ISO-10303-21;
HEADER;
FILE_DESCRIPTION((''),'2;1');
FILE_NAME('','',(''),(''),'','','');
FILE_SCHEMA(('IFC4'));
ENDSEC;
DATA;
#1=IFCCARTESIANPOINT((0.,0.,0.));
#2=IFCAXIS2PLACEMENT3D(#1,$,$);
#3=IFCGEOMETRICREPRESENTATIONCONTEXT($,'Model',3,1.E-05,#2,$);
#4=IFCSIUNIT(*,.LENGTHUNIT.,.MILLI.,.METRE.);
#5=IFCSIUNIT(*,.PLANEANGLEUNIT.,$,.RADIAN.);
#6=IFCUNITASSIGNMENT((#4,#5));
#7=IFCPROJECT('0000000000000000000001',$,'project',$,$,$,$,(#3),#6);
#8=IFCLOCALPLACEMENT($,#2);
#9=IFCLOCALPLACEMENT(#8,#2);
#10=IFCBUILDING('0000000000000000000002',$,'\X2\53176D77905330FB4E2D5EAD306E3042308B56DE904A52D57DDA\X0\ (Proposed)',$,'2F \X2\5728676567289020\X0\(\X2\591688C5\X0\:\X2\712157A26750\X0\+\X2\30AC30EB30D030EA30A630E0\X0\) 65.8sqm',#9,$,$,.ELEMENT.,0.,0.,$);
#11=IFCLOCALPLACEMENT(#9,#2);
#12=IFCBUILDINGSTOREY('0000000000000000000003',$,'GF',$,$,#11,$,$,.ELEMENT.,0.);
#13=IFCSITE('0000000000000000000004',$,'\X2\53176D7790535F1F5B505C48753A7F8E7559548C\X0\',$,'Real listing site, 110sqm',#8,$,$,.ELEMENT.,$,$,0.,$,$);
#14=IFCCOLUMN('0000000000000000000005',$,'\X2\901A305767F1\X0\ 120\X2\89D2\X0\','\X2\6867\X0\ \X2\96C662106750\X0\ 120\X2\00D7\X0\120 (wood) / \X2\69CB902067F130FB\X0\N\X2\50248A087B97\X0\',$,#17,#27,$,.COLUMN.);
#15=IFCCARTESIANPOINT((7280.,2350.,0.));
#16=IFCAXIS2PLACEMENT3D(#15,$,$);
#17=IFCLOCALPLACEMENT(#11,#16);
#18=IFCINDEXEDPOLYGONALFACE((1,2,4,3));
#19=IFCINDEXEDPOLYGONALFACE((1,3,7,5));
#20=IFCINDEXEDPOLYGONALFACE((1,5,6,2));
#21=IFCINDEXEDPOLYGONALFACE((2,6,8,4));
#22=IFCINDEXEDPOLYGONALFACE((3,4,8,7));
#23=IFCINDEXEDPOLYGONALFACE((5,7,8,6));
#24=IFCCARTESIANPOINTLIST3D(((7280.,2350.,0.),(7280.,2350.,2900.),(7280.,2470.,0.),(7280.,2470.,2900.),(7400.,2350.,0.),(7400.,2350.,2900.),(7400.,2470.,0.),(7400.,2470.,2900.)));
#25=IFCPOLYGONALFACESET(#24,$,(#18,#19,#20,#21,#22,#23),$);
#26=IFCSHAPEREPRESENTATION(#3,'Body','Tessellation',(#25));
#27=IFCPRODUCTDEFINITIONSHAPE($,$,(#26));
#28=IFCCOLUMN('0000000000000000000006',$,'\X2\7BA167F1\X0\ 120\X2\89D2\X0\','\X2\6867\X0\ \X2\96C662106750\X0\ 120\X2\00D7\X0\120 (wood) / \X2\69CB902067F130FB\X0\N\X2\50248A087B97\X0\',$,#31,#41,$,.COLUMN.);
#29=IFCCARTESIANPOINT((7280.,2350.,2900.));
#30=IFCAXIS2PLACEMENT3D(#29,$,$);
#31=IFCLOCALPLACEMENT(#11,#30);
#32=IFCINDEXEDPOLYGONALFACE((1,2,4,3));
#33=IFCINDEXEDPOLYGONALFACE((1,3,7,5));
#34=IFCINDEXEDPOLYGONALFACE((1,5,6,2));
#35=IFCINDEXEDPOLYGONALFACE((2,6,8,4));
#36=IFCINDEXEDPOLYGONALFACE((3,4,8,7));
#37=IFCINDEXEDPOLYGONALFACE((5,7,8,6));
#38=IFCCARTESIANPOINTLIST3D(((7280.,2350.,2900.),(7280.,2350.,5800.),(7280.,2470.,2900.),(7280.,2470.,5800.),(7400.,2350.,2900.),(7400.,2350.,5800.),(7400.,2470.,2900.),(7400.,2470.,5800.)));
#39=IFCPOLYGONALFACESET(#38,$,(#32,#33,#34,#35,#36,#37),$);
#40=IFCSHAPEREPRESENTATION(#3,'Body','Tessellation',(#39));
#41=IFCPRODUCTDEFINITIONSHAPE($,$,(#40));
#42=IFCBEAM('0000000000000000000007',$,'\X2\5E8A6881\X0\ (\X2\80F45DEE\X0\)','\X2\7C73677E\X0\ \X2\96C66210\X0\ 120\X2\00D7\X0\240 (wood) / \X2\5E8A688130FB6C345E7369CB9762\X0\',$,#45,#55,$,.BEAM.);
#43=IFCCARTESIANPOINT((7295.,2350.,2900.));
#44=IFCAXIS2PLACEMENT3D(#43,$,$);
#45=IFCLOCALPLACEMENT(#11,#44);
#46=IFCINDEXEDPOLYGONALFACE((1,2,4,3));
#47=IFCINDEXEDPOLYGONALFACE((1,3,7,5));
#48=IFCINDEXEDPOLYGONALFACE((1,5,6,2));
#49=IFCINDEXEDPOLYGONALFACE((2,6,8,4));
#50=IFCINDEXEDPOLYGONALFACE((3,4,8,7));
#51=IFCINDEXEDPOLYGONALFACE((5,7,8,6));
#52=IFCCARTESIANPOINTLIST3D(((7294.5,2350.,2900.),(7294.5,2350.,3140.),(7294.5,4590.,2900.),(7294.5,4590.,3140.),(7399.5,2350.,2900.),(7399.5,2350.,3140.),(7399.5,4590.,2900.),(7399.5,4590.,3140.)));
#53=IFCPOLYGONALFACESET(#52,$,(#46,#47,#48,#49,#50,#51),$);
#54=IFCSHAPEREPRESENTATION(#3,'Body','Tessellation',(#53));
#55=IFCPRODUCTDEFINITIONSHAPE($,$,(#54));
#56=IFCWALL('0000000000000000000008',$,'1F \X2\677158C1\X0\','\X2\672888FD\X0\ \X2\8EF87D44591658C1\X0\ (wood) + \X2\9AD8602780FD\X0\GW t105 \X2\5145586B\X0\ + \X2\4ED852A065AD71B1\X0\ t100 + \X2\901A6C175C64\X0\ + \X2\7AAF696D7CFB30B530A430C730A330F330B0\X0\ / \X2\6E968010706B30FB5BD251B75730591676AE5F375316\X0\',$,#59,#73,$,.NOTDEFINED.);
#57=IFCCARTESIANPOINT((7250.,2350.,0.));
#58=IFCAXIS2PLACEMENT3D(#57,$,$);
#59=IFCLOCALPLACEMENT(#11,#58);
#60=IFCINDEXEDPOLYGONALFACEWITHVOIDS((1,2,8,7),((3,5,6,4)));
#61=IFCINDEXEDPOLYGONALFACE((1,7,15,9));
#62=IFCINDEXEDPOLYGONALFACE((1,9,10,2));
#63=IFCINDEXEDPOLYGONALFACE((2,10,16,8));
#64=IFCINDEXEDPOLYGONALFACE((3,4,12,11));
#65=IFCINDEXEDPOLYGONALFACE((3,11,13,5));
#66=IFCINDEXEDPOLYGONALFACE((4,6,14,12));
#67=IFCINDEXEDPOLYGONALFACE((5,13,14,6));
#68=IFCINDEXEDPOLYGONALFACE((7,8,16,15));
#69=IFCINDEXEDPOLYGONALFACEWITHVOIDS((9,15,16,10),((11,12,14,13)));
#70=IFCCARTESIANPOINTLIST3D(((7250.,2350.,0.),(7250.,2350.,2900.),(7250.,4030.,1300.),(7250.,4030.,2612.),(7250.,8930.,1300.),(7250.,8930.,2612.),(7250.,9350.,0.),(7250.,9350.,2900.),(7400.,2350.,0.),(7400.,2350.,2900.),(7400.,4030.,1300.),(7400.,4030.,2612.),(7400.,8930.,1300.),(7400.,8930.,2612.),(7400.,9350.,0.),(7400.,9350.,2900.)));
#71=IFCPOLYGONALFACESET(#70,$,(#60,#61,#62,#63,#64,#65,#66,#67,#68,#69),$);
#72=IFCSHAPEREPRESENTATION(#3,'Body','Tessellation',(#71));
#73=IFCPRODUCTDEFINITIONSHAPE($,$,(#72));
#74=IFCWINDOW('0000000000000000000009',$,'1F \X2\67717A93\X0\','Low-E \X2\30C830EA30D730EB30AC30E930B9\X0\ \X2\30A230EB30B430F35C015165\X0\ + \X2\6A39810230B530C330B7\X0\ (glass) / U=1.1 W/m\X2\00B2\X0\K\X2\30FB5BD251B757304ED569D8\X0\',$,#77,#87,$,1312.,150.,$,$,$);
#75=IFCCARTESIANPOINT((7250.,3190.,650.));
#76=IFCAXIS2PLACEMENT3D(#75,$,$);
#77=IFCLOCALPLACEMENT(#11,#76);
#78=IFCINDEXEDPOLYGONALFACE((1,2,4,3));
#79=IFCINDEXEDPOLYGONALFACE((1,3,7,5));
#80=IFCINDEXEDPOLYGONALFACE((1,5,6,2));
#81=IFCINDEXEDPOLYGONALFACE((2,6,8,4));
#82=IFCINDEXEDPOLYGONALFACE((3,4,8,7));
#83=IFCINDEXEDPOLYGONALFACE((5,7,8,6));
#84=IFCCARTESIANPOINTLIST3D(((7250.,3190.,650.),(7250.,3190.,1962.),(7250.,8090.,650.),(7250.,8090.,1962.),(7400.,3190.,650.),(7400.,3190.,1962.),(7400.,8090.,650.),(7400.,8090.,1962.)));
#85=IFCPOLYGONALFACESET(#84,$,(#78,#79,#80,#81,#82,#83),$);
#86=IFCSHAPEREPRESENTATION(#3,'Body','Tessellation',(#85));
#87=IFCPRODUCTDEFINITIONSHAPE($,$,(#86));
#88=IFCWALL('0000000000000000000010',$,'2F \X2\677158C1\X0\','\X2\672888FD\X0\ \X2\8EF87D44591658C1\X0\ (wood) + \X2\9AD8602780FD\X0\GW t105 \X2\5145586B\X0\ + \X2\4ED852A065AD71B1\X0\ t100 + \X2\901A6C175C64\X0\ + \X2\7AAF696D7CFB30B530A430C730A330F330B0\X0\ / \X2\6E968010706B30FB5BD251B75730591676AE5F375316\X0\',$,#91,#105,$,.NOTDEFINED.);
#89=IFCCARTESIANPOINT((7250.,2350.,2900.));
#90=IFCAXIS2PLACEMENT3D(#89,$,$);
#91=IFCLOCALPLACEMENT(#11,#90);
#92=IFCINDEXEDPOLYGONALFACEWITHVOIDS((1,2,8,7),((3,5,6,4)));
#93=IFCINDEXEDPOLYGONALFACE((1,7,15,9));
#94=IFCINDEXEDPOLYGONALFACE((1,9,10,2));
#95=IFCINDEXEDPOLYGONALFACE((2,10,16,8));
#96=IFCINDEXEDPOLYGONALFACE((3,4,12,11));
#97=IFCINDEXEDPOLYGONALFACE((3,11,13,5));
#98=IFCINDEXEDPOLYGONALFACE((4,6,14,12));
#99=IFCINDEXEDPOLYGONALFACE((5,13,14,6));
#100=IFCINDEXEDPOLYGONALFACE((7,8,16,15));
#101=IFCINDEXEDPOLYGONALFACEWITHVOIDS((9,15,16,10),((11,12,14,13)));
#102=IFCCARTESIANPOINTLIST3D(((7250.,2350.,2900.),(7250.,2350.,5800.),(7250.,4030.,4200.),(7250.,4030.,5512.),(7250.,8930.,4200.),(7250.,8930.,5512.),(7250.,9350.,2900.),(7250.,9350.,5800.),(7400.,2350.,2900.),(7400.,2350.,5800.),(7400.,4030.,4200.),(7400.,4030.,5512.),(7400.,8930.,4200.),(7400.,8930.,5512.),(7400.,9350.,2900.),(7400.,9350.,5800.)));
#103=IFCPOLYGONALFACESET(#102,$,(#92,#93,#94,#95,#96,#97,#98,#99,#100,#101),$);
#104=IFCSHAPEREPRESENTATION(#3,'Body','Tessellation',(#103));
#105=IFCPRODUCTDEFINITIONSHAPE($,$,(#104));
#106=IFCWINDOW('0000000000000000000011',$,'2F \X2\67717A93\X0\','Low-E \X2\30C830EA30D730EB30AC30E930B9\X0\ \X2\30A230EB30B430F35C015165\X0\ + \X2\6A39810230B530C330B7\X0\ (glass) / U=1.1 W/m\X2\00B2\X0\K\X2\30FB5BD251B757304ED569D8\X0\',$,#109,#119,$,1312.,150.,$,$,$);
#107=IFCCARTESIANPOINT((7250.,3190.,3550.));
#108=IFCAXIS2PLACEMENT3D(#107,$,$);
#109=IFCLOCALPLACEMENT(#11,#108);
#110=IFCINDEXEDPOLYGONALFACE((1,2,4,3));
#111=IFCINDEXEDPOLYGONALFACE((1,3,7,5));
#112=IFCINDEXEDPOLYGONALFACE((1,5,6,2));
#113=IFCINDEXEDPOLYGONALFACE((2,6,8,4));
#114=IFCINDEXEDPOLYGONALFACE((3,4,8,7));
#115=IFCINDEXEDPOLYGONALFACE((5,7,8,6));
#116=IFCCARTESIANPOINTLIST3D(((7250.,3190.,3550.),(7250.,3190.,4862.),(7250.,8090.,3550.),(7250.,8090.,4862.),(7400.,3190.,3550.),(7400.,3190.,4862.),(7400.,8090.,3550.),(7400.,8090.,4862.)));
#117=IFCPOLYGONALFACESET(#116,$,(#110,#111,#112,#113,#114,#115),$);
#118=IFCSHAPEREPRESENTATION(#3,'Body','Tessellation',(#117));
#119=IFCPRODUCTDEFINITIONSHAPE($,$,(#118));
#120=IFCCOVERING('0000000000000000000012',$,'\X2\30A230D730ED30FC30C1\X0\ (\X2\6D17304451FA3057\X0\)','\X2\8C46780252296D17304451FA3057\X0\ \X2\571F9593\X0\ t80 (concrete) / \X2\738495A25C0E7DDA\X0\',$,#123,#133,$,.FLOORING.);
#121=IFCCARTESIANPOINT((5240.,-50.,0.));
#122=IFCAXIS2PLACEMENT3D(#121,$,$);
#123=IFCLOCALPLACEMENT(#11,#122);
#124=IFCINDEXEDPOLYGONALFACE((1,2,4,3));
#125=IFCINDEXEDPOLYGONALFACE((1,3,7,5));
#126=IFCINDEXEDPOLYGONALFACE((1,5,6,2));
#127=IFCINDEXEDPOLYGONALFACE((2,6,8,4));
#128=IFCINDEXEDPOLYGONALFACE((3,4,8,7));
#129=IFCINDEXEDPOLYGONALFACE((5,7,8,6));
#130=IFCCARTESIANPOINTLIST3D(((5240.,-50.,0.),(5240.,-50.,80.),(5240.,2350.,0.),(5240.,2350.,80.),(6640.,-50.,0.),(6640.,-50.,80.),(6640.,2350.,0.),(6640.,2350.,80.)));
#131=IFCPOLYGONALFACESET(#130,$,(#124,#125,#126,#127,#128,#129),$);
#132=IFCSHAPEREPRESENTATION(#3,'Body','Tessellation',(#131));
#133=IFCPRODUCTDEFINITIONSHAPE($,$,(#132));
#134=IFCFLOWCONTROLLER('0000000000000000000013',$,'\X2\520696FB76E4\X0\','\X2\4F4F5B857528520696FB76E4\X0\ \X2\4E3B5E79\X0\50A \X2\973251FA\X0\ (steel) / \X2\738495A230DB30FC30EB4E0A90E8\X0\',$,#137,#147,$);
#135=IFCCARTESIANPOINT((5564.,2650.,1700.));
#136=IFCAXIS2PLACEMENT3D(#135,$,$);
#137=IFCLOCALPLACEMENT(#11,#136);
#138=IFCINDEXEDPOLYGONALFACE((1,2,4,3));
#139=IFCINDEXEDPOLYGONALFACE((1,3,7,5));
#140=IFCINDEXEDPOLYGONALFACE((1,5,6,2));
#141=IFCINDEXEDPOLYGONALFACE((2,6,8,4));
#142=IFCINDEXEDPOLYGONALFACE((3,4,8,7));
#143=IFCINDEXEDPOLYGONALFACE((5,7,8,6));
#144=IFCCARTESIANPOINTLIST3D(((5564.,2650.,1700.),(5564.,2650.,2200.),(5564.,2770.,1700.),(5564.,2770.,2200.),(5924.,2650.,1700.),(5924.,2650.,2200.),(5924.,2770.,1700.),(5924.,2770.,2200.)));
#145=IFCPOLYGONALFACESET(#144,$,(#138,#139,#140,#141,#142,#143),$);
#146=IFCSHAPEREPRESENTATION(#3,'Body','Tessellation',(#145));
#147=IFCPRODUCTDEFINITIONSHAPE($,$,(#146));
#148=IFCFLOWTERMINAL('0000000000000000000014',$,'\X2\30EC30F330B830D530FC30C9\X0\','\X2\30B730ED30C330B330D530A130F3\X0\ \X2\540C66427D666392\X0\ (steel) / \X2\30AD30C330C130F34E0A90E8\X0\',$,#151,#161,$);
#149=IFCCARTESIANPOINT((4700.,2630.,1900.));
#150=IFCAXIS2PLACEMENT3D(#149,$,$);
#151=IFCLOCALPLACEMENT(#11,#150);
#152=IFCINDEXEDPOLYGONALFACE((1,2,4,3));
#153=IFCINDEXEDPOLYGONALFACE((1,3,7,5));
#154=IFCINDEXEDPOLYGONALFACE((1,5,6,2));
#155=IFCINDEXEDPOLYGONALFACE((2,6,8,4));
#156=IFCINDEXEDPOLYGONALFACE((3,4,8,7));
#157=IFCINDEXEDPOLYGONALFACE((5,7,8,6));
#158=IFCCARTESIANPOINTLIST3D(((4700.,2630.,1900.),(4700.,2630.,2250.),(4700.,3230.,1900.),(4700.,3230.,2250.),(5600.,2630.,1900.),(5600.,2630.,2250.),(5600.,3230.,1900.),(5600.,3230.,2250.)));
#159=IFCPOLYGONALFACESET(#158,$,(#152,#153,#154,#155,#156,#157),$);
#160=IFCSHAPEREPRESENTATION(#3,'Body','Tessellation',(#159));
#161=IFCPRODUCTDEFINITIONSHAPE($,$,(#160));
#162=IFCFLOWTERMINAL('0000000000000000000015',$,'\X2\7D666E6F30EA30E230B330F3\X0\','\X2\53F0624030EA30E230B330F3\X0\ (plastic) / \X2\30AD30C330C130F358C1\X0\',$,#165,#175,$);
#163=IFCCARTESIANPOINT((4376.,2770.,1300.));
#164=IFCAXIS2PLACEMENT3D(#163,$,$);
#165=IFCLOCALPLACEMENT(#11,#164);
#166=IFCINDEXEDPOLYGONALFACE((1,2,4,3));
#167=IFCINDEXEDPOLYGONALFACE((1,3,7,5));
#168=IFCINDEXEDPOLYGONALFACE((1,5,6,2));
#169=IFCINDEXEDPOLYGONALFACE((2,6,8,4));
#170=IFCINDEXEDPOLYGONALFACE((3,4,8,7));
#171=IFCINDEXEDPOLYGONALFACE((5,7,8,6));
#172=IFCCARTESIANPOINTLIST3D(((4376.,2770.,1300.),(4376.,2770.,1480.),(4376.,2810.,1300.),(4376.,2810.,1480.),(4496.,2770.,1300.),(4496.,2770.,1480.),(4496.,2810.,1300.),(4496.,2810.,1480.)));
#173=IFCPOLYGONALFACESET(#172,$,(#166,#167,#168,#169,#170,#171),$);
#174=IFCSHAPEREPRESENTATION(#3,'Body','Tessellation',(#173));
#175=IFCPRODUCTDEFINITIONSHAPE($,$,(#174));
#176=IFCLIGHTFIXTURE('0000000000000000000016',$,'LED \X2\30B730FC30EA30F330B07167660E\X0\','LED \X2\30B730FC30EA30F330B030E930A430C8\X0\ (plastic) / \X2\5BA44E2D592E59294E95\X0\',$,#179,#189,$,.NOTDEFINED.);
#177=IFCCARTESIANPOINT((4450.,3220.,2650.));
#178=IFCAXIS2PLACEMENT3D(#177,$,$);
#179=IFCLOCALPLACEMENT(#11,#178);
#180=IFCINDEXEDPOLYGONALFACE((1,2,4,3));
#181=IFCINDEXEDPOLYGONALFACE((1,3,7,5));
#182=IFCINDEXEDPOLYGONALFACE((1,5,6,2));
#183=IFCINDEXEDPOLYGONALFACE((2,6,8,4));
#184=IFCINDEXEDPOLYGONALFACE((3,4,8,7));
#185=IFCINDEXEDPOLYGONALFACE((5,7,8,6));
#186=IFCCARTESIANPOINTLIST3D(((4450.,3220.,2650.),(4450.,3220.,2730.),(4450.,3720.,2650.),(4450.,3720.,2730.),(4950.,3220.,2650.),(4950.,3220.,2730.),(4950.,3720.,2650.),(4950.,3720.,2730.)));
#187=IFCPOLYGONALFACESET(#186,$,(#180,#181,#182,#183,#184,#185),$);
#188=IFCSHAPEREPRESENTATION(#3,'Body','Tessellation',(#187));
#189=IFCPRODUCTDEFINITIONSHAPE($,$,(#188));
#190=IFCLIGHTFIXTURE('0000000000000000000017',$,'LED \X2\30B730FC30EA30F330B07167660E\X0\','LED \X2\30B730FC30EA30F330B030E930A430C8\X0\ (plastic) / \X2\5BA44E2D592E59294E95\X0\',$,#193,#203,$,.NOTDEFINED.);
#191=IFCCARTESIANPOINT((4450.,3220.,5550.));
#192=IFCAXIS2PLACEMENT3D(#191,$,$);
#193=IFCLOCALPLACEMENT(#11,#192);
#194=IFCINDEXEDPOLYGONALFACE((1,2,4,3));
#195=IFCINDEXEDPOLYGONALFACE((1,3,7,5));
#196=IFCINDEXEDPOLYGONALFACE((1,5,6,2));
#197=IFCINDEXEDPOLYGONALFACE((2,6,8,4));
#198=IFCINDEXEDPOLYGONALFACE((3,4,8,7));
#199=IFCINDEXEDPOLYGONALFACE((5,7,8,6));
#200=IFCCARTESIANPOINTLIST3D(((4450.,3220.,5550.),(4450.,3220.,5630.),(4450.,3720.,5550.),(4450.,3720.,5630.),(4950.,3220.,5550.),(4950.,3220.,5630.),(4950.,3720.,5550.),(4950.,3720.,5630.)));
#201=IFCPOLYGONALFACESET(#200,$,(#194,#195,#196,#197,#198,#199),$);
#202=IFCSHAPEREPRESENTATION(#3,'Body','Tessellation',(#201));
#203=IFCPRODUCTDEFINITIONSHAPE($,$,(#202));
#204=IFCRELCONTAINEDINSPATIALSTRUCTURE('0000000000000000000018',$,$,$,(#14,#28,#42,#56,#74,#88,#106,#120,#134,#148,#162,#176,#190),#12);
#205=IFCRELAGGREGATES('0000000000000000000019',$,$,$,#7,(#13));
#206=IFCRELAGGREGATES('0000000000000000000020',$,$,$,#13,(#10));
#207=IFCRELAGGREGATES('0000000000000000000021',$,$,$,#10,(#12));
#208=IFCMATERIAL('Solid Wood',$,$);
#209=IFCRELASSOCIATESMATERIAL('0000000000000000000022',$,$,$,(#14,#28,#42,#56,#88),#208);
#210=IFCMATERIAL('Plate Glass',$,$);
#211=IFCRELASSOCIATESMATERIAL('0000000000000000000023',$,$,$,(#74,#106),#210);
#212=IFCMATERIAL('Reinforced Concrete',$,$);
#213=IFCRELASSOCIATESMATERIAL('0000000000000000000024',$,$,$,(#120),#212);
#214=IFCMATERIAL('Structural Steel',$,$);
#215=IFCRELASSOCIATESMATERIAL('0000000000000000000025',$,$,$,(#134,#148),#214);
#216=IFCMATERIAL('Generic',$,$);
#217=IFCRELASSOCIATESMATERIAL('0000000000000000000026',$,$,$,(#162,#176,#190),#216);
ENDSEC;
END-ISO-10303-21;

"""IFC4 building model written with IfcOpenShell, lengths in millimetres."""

from ifc_helpers import new_model, si_unit, frame, frame_2d, origin, place, context, project, spatial, rectangle, extrude, material, element, fill, save


model = new_model("IFC4")

# Units and contexts
model_context = context("Model", 3, precision=1e-05, world=origin())
ifc_project = project(units=[si_unit("LENGTHUNIT", "METRE", prefix="MILLI"), si_unit("PLANEANGLEUNIT", "RADIAN")], contexts=[model_context])

# Site, building, storey
site_placement = place(None, origin())
site = spatial("IfcSite", under=ifc_project, at=site_placement, Name="北海道弟子屈町美留和", ObjectType="Real listing site, 110sqm", CompositionType="ELEMENT", RefElevation=0.0)
building_placement = place(site_placement, origin())
building = spatial("IfcBuilding", under=site, at=building_placement, Name="北海道・中庭のある回遊動線 (Proposed)", ObjectType="2F 在来木造(外装:無垢材+ガルバリウム) 65.8sqm", CompositionType="ELEMENT", ElevationOfRefHeight=0.0, ElevationOfTerrain=0.0)
storey_placement = place(building_placement, origin())
storey = spatial("IfcBuildingStorey", under=building, at=storey_placement, Name="GF", CompositionType="ELEMENT", Elevation=0.0)

# Columns
ifc_material_1 = material(Name="Solid Wood")
column_1_placement = place(storey_placement, frame((7280.0, 2350.0, 0.0)))
element("IfcColumn", 1, at=column_1_placement, inside=storey, material=ifc_material_1, Name="通し柱 120角", Description="桧 集成材 120×120 (wood) / 構造柱・N値計算", PredefinedType="COLUMN", context=model_context, shape_type="SweptSolid", body=[
    extrude(rectangle(XDim=120.0, YDim=120.0, at=frame_2d((60.0, 60.0))), frame((7280.0, 2350.0, 0.0)), (0.0, 0.0, 1.0), 2900.0),
])
column_2_placement = place(storey_placement, frame((7280.0, 2350.0, 2900.0)))
element("IfcColumn", 2, at=column_2_placement, inside=storey, material=ifc_material_1, Name="管柱 120角", Description="桧 集成材 120×120 (wood) / 構造柱・N値計算", PredefinedType="COLUMN", context=model_context, shape_type="SweptSolid", body=[
    extrude(rectangle(XDim=120.0, YDim=120.0, at=frame_2d((60.0, 60.0))), frame((7280.0, 2350.0, 2900.0)), (0.0, 0.0, 1.0), 2900.0),
])

# Beam
beam_1_placement = place(storey_placement, frame((7295.0, 2350.0, 2900.0)))
element("IfcBeam", 3, at=beam_1_placement, inside=storey, material=ifc_material_1, Name="床梁 (胴差)", Description="米松 集成 120×240 (wood) / 床梁・水平構面", PredefinedType="BEAM", context=model_context, shape_type="SweptSolid", body=[
    extrude(rectangle(XDim=105.0, YDim=2240.0, at=frame_2d((52.0, 1120.0))), frame((7295.0, 2350.0, 2900.0)), (0.0, 0.0, 1.0), 240.0),
])

# Wall, opening, window
wall_1_placement = place(storey_placement, frame((7250.0, 2350.0, 0.0)))
wall_1 = element("IfcWall", 4, at=wall_1_placement, inside=storey, material=ifc_material_1, Name="1F 東壁", Description="木製 軸組外壁 (wood) + 高性能GW t105 充填 + 付加断熱 t100 + 通気層 + 窯業系サイディング / 準耐火・寒冷地外皮強化", PredefinedType="NOTDEFINED", context=model_context, shape_type="SweptSolid", body=[
    extrude(rectangle(XDim=150.0, YDim=7000.0, at=frame_2d((75.0, 3500.0))), frame((7250.0, 2350.0, 0.0)), (0.0, 0.0, 1.0), 2900.0),
])
opening_1_placement = place(storey_placement, frame((7250.0, 3190.0, 650.0)))
opening_1 = element("IfcOpeningElement", 5, at=opening_1_placement, cuts=wall_1, PredefinedType="NOTDEFINED", context=model_context, shape_type="SweptSolid", body=[
    extrude(rectangle(XDim=150.0, YDim=4900.0, at=frame_2d((75.0, 2450.0))), frame((7250.0, 3190.0, 650.0)), (0.0, 0.0, 1.0), 1312.0),
])
ifc_material_2 = material(Name="Plate Glass")
window_1_placement = place(storey_placement, frame((7250.0, 3190.0, 650.0)))
window_1 = element("IfcWindow", 6, at=window_1_placement, inside=storey, material=ifc_material_2, Name="1F 東窓", Description="Low-E トリプルガラス アルゴン封入 + 樹脂サッシ (glass) / U=1.1 W/m²K・寒冷地仕様", OverallHeight=1312.0, OverallWidth=150.0, context=model_context, shape_type="SweptSolid", body=[
    extrude(rectangle(XDim=150.0, YDim=4900.0, at=frame_2d((75.0, 2450.0))), frame((7250.0, 3190.0, 650.0)), (0.0, 0.0, 1.0), 1312.0),
])
fill(opening_1, window_1)

# Wall, opening, window
wall_2_placement = place(storey_placement, frame((7250.0, 2350.0, 2900.0)))
wall_2 = element("IfcWall", 7, at=wall_2_placement, inside=storey, material=ifc_material_1, Name="2F 東壁", Description="木製 軸組外壁 (wood) + 高性能GW t105 充填 + 付加断熱 t100 + 通気層 + 窯業系サイディング / 準耐火・寒冷地外皮強化", PredefinedType="NOTDEFINED", context=model_context, shape_type="SweptSolid", body=[
    extrude(rectangle(XDim=150.0, YDim=7000.0, at=frame_2d((75.0, 3500.0))), frame((7250.0, 2350.0, 2900.0)), (0.0, 0.0, 1.0), 2900.0),
])
opening_2_placement = place(storey_placement, frame((7250.0, 3190.0, 3550.0)))
opening_2 = element("IfcOpeningElement", 8, at=opening_2_placement, cuts=wall_2, PredefinedType="NOTDEFINED", context=model_context, shape_type="SweptSolid", body=[
    extrude(rectangle(XDim=150.0, YDim=4900.0, at=frame_2d((75.0, 2450.0))), frame((7250.0, 3190.0, 3550.0)), (0.0, 0.0, 1.0), 1312.0),
])
window_2_placement = place(storey_placement, frame((7250.0, 3190.0, 3550.0)))
window_2 = element("IfcWindow", 9, at=window_2_placement, inside=storey, material=ifc_material_2, Name="2F 東窓", Description="Low-E トリプルガラス アルゴン封入 + 樹脂サッシ (glass) / U=1.1 W/m²K・寒冷地仕様", OverallHeight=1312.0, OverallWidth=150.0, context=model_context, shape_type="SweptSolid", body=[
    extrude(rectangle(XDim=150.0, YDim=4900.0, at=frame_2d((75.0, 2450.0))), frame((7250.0, 3190.0, 3550.0)), (0.0, 0.0, 1.0), 1312.0),
])
fill(opening_2, window_2)

# Covering
ifc_material_3 = material(Name="Reinforced Concrete")
covering_placement = place(storey_placement, frame((5240.0, -50.0, 0.0)))
element("IfcCovering", 10, at=covering_placement, inside=storey, material=ifc_material_3, Name="アプローチ (洗い出し)", Description="豆砂利洗い出し 土間 t80 (concrete) / 玄関導線", PredefinedType="FLOORING", context=model_context, shape_type="SweptSolid", body=[
    extrude(rectangle(XDim=1400.0, YDim=2400.0, at=frame_2d((700.0, 1200.0))), frame((5240.0, -50.0, 0.0)), (0.0, 0.0, 1.0), 80.0),
])

# Flow controller
ifc_material_4 = material(Name="Structural Steel")
flow_controller_placement = place(storey_placement, frame((5564.0, 2650.0, 1700.0)))
element("IfcFlowController", 11, at=flow_controller_placement, inside=storey, material=ifc_material_4, Name="分電盤", Description="住宅用分電盤 主幹50A 露出 (steel) / 玄関ホール上部", context=model_context, shape_type="SweptSolid", body=[
    extrude(rectangle(XDim=360.0, YDim=120.0, at=frame_2d((180.0, 60.0))), frame((5564.0, 2650.0, 1700.0)), (0.0, 0.0, 1.0), 500.0),
])

# Flow terminals
flow_terminal_1_placement = place(storey_placement, frame((4700.0, 2630.0, 1900.0)))
element("IfcFlowTerminal", 12, at=flow_terminal_1_placement, inside=storey, material=ifc_material_4, Name="レンジフード", Description="シロッコファン 同時給排 (steel) / キッチン上部", context=model_context, shape_type="SweptSolid", body=[
    extrude(rectangle(XDim=900.0, YDim=600.0, at=frame_2d((450.0, 300.0))), frame((4700.0, 2630.0, 1900.0)), (0.0, 0.0, 1.0), 350.0),
])
ifc_material_5 = material(Name="Generic")
flow_terminal_2_placement = place(storey_placement, frame((4376.0, 2770.0, 1300.0)))
element("IfcFlowTerminal", 13, at=flow_terminal_2_placement, inside=storey, material=ifc_material_5, Name="給湯リモコン", Description="台所リモコン (plastic) / キッチン壁", context=model_context, shape_type="SweptSolid", body=[
    extrude(rectangle(XDim=120.0, YDim=40.0, at=frame_2d((60.0, 20.0))), frame((4376.0, 2770.0, 1300.0)), (0.0, 0.0, 1.0), 180.0),
])

# Light fixtures
light_fixture_1_placement = place(storey_placement, frame((4450.0, 3220.0, 2650.0)))
element("IfcLightFixture", 14, at=light_fixture_1_placement, inside=storey, material=ifc_material_5, Name="LED シーリング照明", Description="LED シーリングライト (plastic) / 室中央天井", PredefinedType="NOTDEFINED", context=model_context, shape_type="SweptSolid", body=[
    extrude(rectangle(XDim=500.0, YDim=500.0, at=frame_2d((250.0, 250.0))), frame((4450.0, 3220.0, 2650.0)), (0.0, 0.0, 1.0), 80.0),
])
light_fixture_2_placement = place(storey_placement, frame((4450.0, 3220.0, 5550.0)))
element("IfcLightFixture", 15, at=light_fixture_2_placement, inside=storey, material=ifc_material_5, Name="LED シーリング照明", Description="LED シーリングライト (plastic) / 室中央天井", PredefinedType="NOTDEFINED", context=model_context, shape_type="SweptSolid", body=[
    extrude(rectangle(XDim=500.0, YDim=500.0, at=frame_2d((250.0, 250.0))), frame((4450.0, 3220.0, 5550.0)), (0.0, 0.0, 1.0), 80.0),
])

save(model, "model.ifc")
